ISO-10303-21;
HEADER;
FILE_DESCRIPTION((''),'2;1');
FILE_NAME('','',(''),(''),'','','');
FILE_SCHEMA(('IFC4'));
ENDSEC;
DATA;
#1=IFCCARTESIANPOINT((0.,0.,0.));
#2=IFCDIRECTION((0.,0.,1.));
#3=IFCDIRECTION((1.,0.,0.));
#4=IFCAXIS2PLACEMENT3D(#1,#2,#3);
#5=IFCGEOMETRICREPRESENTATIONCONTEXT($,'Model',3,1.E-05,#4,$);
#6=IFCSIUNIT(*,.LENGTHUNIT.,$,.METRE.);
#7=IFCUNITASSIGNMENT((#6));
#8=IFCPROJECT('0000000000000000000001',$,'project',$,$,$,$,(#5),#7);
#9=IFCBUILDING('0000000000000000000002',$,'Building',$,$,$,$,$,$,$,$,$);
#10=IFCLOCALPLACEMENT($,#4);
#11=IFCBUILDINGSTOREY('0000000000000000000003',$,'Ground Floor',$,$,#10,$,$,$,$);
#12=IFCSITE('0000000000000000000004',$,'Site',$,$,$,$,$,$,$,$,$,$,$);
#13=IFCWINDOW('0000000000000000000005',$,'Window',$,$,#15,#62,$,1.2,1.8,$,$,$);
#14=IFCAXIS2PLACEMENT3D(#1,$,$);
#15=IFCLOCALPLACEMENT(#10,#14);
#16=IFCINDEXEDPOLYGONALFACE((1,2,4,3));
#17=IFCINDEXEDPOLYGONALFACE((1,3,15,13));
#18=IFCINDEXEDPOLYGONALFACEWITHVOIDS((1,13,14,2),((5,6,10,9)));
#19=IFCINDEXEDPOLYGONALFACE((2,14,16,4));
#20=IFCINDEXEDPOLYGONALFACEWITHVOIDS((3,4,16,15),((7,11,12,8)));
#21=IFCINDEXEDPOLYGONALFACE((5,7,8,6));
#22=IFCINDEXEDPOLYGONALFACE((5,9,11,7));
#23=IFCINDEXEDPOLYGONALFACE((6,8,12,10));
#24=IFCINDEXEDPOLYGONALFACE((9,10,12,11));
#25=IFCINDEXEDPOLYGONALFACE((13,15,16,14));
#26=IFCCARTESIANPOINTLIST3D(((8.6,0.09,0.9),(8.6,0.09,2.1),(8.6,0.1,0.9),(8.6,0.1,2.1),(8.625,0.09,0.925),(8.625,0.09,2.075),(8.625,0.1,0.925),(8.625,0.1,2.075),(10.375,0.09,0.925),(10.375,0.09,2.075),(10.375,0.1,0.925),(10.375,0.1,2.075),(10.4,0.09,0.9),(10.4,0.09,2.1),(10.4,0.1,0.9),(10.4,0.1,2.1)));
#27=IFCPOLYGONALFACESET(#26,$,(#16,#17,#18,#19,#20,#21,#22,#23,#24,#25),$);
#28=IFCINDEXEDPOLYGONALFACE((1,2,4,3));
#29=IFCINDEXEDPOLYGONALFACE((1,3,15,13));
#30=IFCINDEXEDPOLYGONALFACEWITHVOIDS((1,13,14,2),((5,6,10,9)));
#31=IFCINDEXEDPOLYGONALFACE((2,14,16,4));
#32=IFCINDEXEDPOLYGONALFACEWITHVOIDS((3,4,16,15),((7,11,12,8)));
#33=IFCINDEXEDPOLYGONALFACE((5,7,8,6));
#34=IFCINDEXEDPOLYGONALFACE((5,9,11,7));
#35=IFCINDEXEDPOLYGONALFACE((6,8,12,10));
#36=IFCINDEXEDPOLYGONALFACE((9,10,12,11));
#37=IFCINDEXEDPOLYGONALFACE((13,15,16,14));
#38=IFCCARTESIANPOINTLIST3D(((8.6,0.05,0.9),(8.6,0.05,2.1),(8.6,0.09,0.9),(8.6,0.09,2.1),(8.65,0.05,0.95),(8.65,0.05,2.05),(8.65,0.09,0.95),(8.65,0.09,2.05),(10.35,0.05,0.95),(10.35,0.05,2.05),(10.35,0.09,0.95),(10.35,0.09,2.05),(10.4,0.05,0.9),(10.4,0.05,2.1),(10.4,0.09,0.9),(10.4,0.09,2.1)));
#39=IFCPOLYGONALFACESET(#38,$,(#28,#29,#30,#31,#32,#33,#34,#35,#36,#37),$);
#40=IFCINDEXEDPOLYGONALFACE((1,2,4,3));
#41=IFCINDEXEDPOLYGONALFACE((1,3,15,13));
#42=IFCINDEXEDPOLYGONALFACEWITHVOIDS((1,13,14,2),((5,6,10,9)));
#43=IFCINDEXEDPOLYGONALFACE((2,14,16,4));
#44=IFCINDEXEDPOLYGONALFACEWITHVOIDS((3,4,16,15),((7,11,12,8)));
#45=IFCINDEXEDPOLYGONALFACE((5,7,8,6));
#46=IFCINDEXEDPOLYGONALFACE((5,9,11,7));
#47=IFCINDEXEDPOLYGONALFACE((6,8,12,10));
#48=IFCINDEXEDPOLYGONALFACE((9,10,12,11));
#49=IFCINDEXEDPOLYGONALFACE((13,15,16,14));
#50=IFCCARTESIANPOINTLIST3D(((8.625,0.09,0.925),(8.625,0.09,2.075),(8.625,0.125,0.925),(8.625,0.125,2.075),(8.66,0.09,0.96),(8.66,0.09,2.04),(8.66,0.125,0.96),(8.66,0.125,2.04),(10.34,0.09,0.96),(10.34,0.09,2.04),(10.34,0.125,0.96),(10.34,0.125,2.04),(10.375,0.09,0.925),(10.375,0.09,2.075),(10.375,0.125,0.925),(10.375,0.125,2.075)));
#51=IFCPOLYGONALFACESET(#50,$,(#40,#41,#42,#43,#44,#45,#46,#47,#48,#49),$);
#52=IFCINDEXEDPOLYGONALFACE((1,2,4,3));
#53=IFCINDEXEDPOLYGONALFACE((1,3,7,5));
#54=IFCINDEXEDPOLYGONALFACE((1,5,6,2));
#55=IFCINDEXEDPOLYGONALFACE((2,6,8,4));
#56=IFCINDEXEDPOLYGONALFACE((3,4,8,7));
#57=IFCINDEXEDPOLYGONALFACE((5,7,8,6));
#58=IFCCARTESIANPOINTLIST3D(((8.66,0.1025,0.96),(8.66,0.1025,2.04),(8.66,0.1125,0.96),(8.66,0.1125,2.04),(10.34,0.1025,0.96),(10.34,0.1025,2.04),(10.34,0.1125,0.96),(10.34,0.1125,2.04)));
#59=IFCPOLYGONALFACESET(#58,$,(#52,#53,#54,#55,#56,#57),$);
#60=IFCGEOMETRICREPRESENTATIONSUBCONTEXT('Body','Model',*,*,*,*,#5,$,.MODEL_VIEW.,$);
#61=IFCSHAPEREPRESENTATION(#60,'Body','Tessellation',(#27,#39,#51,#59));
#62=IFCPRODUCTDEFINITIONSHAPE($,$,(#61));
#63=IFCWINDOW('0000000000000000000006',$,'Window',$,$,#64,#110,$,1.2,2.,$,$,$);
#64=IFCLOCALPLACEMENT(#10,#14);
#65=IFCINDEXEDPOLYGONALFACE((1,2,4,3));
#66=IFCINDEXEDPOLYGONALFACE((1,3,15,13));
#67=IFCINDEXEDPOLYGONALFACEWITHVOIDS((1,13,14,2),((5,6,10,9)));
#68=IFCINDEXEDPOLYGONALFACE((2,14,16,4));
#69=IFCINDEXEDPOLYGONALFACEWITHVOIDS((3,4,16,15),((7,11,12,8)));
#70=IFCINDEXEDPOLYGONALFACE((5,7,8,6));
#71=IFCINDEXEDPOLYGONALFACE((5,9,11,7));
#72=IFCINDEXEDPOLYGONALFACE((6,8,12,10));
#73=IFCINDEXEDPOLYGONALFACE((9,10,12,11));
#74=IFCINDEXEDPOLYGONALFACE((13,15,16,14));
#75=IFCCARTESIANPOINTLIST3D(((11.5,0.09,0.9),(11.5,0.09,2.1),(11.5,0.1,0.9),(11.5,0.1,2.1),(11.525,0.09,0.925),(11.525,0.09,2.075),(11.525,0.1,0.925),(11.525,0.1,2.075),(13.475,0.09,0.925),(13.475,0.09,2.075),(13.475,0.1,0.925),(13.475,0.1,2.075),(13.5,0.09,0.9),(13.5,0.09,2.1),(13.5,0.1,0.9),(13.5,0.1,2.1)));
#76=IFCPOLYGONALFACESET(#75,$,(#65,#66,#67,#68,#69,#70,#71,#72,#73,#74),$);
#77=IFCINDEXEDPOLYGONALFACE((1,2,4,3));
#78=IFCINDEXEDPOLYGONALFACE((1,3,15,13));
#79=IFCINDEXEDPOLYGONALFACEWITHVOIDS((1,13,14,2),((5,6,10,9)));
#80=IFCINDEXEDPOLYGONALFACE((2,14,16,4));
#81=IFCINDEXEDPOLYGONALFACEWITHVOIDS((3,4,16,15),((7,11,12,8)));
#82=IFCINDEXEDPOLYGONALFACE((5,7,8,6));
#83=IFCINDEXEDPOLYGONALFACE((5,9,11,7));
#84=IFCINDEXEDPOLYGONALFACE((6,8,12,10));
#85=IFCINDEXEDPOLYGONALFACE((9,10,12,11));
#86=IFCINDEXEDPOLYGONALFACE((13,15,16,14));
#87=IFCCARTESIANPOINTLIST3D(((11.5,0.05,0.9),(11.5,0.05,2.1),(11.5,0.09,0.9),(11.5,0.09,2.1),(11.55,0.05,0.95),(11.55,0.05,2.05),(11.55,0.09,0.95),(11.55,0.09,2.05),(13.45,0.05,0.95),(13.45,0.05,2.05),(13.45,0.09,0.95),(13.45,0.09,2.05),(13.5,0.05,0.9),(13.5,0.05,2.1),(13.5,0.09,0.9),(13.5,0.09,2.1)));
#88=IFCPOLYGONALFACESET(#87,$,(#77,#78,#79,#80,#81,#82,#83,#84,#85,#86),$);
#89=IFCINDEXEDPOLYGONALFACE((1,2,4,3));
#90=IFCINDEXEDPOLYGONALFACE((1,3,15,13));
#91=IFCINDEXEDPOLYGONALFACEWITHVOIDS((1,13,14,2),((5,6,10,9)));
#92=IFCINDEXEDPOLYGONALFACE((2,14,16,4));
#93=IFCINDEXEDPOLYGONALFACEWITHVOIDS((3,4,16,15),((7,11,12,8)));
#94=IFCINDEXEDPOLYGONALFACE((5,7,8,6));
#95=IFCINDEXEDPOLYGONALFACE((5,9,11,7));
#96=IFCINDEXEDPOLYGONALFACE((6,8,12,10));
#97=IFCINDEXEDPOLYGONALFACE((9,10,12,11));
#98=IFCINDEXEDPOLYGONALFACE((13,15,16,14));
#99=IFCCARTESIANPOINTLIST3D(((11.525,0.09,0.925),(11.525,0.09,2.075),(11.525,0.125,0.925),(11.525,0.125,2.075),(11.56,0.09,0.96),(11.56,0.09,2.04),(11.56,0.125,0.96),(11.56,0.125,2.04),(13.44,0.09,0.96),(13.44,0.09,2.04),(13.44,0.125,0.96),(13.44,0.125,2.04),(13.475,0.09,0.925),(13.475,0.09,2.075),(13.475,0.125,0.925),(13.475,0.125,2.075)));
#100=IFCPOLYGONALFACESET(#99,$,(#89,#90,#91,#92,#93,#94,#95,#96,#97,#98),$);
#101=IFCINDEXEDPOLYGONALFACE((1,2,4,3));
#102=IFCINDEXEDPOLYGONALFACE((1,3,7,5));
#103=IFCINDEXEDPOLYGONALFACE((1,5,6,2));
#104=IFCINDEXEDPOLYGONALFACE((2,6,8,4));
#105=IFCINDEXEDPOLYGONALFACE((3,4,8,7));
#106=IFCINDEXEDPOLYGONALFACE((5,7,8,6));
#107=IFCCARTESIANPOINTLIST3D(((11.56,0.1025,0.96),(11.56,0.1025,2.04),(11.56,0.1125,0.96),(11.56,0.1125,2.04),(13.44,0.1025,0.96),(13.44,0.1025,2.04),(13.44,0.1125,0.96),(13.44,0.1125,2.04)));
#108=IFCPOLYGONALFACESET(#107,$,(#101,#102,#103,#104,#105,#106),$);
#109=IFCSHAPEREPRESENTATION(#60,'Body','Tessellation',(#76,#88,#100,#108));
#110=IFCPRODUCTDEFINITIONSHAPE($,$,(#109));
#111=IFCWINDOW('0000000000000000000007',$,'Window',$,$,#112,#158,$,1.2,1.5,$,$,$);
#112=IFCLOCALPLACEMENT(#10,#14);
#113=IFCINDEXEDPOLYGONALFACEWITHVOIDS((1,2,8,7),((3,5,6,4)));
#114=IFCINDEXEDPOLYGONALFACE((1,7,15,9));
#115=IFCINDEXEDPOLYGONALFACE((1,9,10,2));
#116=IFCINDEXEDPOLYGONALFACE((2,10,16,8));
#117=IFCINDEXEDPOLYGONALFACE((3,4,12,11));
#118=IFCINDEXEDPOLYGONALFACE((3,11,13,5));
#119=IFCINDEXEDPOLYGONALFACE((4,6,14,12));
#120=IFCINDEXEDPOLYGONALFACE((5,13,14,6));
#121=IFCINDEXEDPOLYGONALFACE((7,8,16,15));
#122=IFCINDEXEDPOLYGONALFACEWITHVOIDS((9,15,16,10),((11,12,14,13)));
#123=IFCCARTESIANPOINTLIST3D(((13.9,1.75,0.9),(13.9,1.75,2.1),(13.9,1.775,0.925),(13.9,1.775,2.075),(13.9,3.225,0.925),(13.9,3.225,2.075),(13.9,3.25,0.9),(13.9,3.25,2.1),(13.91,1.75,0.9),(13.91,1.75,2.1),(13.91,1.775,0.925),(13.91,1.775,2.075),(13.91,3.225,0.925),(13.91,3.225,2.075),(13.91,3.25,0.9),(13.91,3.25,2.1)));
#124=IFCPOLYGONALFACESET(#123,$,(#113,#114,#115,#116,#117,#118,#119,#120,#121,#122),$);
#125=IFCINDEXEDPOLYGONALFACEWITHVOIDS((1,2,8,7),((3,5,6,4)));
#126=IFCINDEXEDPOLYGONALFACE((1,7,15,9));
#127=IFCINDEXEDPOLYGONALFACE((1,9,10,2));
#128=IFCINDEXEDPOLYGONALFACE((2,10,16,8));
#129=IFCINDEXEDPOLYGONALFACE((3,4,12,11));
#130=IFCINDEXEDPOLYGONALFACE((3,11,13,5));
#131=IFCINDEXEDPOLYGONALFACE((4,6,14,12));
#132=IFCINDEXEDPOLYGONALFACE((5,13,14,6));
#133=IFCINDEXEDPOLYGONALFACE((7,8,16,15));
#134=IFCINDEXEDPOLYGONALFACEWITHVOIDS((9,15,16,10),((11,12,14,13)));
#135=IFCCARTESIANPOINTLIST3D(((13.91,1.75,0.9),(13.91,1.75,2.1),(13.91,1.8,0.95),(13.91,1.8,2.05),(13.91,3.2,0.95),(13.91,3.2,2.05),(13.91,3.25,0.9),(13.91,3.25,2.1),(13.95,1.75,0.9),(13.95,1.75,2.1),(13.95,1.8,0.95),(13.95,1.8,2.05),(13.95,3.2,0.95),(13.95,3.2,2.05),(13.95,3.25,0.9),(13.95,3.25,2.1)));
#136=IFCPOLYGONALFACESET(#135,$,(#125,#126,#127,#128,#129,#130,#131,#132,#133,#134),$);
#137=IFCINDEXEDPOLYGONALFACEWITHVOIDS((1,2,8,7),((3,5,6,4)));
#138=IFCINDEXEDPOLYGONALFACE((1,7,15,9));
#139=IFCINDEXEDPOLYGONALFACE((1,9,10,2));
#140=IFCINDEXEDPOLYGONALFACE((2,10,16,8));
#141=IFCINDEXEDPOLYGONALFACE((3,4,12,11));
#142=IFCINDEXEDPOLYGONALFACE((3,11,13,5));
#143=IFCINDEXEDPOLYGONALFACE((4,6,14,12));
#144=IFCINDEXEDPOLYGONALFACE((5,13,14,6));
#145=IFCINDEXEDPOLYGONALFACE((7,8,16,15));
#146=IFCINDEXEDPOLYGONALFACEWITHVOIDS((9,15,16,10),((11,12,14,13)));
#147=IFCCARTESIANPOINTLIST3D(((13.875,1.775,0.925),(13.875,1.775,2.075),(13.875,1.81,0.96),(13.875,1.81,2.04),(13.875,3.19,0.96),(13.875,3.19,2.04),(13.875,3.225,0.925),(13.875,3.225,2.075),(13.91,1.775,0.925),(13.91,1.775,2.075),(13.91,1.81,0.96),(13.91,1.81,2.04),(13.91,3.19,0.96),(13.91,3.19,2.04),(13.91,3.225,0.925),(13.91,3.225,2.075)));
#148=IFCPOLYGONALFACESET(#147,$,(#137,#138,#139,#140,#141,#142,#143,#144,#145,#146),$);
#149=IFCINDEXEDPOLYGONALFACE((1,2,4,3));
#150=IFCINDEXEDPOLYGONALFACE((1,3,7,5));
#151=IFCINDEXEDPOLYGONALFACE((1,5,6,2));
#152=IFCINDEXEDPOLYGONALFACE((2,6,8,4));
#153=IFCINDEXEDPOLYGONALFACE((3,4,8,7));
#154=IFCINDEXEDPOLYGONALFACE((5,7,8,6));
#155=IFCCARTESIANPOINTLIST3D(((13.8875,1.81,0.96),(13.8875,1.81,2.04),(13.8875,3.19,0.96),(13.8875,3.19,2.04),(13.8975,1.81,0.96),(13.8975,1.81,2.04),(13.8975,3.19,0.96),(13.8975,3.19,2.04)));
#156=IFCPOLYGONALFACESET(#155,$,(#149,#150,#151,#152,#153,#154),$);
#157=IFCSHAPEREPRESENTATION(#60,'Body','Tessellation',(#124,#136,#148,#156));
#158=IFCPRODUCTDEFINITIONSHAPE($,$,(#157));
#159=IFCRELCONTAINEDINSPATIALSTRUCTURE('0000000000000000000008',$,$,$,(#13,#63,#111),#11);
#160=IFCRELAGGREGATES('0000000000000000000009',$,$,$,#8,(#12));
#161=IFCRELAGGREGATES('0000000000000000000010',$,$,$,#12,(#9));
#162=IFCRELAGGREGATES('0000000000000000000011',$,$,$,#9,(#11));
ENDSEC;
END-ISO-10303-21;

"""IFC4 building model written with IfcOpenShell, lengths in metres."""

from ifc_helpers import new_model, si_unit, frame, origin_with_axes, place, context, subcontext, project, spatial, line, indexed_curve, outline, extrude, element, save


model = new_model("IFC4")

# Units and contexts
model_context = context("Model", 3, precision=1e-05, world=origin_with_axes())
body_context = subcontext(model_context, "Body", "Model", "MODEL_VIEW")
ifc_project = project(units=[si_unit("LENGTHUNIT", "METRE")], contexts=[model_context])

# Site, building, storey
site = spatial("IfcSite", under=ifc_project, Name="Site")
building = spatial("IfcBuilding", under=site, Name="Building")
storey_placement = place(None, origin_with_axes())
storey = spatial("IfcBuildingStorey", under=building, at=storey_placement, Name="Ground Floor")

# Windows
window_1_placement = place(storey_placement, frame((8.6, 0.0, 0.9), z_axis=(0.0, 0.0, 1.0), x_axis=(1.0, 0.0, 0.0)))
element("IfcWindow", 1, at=window_1_placement, inside=storey, Name="Window", OverallHeight=1.2, OverallWidth=1.8, context=body_context, shape_type="SweptSolid", body=[
    extrude(outline(indexed_curve([(0.0, 0.0), (1.8, 0.0), (1.8, 1.2), (0.0, 1.2)], segments=[line(1, 2, 3, 4, 1)]), holes=[indexed_curve([(0.025, 0.025), (1.775, 0.025), (1.775, 1.175), (0.025, 1.175)], segments=[line(1, 2, 3, 4, 1)])]), frame((0.0, 0.09, 0.0), z_axis=(0.0, -1.0, 0.0), x_axis=(1.0, 0.0, 0.0)), (0.0, 0.0, -1.0), 0.01),
    extrude(outline(indexed_curve([(0.0, 0.0), (1.8, 0.0), (1.8, 1.2), (0.0, 1.2)], segments=[line(1, 2, 3, 4, 1)]), holes=[indexed_curve([(0.05, 0.05), (1.75, 0.05), (1.75, 1.15), (0.05, 1.15)], segments=[line(1, 2, 3, 4, 1)])]), frame((0.0, 0.05, 0.0), z_axis=(0.0, -1.0, 0.0), x_axis=(1.0, 0.0, 0.0)), (0.0, 0.0, -1.0), 0.04),
    extrude(outline(indexed_curve([(0.0, 0.0), (1.75, 0.0), (1.75, 1.15), (0.0, 1.15)], segments=[line(1, 2, 3, 4, 1)]), holes=[indexed_curve([(0.035, 0.035), (1.715, 0.035), (1.715, 1.115), (0.035, 1.115)], segments=[line(1, 2, 3, 4, 1)])]), frame((0.025, 0.09, 0.025), z_axis=(0.0, -1.0, 0.0), x_axis=(1.0, 0.0, 0.0)), (0.0, 0.0, -1.0), 0.035),
    extrude(outline(indexed_curve([(0.035, 0.035), (1.715, 0.035), (1.715, 1.115), (0.035, 1.115)], segments=[line(1, 2, 3, 4, 1)])), frame((0.025, 0.1025, 0.025), z_axis=(0.0, -1.0, 0.0), x_axis=(1.0, 0.0, 0.0)), (0.0, 0.0, -1.0), 0.01),
])
window_2_placement = place(storey_placement, frame((11.5, 0.0, 0.9), z_axis=(0.0, 0.0, 1.0), x_axis=(1.0, 0.0, 0.0)))
element("IfcWindow", 2, at=window_2_placement, inside=storey, Name="Window", OverallHeight=1.2, OverallWidth=2.0, context=body_context, shape_type="SweptSolid", body=[
    extrude(outline(indexed_curve([(0.0, 0.0), (2.0, 0.0), (2.0, 1.2), (0.0, 1.2)], segments=[line(1, 2, 3, 4, 1)]), holes=[indexed_curve([(0.025, 0.025), (1.975, 0.025), (1.975, 1.175), (0.025, 1.175)], segments=[line(1, 2, 3, 4, 1)])]), frame((0.0, 0.09, 0.0), z_axis=(0.0, -1.0, 0.0), x_axis=(1.0, 0.0, 0.0)), (0.0, 0.0, -1.0), 0.01),
    extrude(outline(indexed_curve([(0.0, 0.0), (2.0, 0.0), (2.0, 1.2), (0.0, 1.2)], segments=[line(1, 2, 3, 4, 1)]), holes=[indexed_curve([(0.05, 0.05), (1.95, 0.05), (1.95, 1.15), (0.05, 1.15)], segments=[line(1, 2, 3, 4, 1)])]), frame((0.0, 0.05, 0.0), z_axis=(0.0, -1.0, 0.0), x_axis=(1.0, 0.0, 0.0)), (0.0, 0.0, -1.0), 0.04),
    extrude(outline(indexed_curve([(0.0, 0.0), (1.95, 0.0), (1.95, 1.15), (0.0, 1.15)], segments=[line(1, 2, 3, 4, 1)]), holes=[indexed_curve([(0.035, 0.035), (1.915, 0.035), (1.915, 1.115), (0.035, 1.115)], segments=[line(1, 2, 3, 4, 1)])]), frame((0.025, 0.09, 0.025), z_axis=(0.0, -1.0, 0.0), x_axis=(1.0, 0.0, 0.0)), (0.0, 0.0, -1.0), 0.035),
    extrude(outline(indexed_curve([(0.035, 0.035), (1.915, 0.035), (1.915, 1.115), (0.035, 1.115)], segments=[line(1, 2, 3, 4, 1)])), frame((0.025, 0.1025, 0.025), z_axis=(0.0, -1.0, 0.0), x_axis=(1.0, 0.0, 0.0)), (0.0, 0.0, -1.0), 0.01),
])
window_3_placement = place(storey_placement, frame((14.0, 1.75, 0.9), z_axis=(0.0, 0.0, 1.0), x_axis=(0.0, 1.0, 0.0)))
element("IfcWindow", 3, at=window_3_placement, inside=storey, Name="Window", OverallHeight=1.2, OverallWidth=1.5, context=body_context, shape_type="SweptSolid", body=[
    extrude(outline(indexed_curve([(0.0, 0.0), (1.5, 0.0), (1.5, 1.2), (0.0, 1.2)], segments=[line(1, 2, 3, 4, 1)]), holes=[indexed_curve([(0.025, 0.025), (1.475, 0.025), (1.475, 1.175), (0.025, 1.175)], segments=[line(1, 2, 3, 4, 1)])]), frame((0.0, 0.09, 0.0), z_axis=(0.0, -1.0, 0.0), x_axis=(1.0, 0.0, 0.0)), (0.0, 0.0, -1.0), 0.01),
    extrude(outline(indexed_curve([(0.0, 0.0), (1.5, 0.0), (1.5, 1.2), (0.0, 1.2)], segments=[line(1, 2, 3, 4, 1)]), holes=[indexed_curve([(0.05, 0.05), (1.45, 0.05), (1.45, 1.15), (0.05, 1.15)], segments=[line(1, 2, 3, 4, 1)])]), frame((0.0, 0.05, 0.0), z_axis=(0.0, -1.0, 0.0), x_axis=(1.0, 0.0, 0.0)), (0.0, 0.0, -1.0), 0.04),
    extrude(outline(indexed_curve([(0.0, 0.0), (1.45, 0.0), (1.45, 1.15), (0.0, 1.15)], segments=[line(1, 2, 3, 4, 1)]), holes=[indexed_curve([(0.035, 0.035), (1.415, 0.035), (1.415, 1.115), (0.035, 1.115)], segments=[line(1, 2, 3, 4, 1)])]), frame((0.025, 0.09, 0.025), z_axis=(0.0, -1.0, 0.0), x_axis=(1.0, 0.0, 0.0)), (0.0, 0.0, -1.0), 0.035),
    extrude(outline(indexed_curve([(0.035, 0.035), (1.415, 0.035), (1.415, 1.115), (0.035, 1.115)], segments=[line(1, 2, 3, 4, 1)])), frame((0.025, 0.1025, 0.025), z_axis=(0.0, -1.0, 0.0), x_axis=(1.0, 0.0, 0.0)), (0.0, 0.0, -1.0), 0.01),
])

save(model, "model.ifc")
